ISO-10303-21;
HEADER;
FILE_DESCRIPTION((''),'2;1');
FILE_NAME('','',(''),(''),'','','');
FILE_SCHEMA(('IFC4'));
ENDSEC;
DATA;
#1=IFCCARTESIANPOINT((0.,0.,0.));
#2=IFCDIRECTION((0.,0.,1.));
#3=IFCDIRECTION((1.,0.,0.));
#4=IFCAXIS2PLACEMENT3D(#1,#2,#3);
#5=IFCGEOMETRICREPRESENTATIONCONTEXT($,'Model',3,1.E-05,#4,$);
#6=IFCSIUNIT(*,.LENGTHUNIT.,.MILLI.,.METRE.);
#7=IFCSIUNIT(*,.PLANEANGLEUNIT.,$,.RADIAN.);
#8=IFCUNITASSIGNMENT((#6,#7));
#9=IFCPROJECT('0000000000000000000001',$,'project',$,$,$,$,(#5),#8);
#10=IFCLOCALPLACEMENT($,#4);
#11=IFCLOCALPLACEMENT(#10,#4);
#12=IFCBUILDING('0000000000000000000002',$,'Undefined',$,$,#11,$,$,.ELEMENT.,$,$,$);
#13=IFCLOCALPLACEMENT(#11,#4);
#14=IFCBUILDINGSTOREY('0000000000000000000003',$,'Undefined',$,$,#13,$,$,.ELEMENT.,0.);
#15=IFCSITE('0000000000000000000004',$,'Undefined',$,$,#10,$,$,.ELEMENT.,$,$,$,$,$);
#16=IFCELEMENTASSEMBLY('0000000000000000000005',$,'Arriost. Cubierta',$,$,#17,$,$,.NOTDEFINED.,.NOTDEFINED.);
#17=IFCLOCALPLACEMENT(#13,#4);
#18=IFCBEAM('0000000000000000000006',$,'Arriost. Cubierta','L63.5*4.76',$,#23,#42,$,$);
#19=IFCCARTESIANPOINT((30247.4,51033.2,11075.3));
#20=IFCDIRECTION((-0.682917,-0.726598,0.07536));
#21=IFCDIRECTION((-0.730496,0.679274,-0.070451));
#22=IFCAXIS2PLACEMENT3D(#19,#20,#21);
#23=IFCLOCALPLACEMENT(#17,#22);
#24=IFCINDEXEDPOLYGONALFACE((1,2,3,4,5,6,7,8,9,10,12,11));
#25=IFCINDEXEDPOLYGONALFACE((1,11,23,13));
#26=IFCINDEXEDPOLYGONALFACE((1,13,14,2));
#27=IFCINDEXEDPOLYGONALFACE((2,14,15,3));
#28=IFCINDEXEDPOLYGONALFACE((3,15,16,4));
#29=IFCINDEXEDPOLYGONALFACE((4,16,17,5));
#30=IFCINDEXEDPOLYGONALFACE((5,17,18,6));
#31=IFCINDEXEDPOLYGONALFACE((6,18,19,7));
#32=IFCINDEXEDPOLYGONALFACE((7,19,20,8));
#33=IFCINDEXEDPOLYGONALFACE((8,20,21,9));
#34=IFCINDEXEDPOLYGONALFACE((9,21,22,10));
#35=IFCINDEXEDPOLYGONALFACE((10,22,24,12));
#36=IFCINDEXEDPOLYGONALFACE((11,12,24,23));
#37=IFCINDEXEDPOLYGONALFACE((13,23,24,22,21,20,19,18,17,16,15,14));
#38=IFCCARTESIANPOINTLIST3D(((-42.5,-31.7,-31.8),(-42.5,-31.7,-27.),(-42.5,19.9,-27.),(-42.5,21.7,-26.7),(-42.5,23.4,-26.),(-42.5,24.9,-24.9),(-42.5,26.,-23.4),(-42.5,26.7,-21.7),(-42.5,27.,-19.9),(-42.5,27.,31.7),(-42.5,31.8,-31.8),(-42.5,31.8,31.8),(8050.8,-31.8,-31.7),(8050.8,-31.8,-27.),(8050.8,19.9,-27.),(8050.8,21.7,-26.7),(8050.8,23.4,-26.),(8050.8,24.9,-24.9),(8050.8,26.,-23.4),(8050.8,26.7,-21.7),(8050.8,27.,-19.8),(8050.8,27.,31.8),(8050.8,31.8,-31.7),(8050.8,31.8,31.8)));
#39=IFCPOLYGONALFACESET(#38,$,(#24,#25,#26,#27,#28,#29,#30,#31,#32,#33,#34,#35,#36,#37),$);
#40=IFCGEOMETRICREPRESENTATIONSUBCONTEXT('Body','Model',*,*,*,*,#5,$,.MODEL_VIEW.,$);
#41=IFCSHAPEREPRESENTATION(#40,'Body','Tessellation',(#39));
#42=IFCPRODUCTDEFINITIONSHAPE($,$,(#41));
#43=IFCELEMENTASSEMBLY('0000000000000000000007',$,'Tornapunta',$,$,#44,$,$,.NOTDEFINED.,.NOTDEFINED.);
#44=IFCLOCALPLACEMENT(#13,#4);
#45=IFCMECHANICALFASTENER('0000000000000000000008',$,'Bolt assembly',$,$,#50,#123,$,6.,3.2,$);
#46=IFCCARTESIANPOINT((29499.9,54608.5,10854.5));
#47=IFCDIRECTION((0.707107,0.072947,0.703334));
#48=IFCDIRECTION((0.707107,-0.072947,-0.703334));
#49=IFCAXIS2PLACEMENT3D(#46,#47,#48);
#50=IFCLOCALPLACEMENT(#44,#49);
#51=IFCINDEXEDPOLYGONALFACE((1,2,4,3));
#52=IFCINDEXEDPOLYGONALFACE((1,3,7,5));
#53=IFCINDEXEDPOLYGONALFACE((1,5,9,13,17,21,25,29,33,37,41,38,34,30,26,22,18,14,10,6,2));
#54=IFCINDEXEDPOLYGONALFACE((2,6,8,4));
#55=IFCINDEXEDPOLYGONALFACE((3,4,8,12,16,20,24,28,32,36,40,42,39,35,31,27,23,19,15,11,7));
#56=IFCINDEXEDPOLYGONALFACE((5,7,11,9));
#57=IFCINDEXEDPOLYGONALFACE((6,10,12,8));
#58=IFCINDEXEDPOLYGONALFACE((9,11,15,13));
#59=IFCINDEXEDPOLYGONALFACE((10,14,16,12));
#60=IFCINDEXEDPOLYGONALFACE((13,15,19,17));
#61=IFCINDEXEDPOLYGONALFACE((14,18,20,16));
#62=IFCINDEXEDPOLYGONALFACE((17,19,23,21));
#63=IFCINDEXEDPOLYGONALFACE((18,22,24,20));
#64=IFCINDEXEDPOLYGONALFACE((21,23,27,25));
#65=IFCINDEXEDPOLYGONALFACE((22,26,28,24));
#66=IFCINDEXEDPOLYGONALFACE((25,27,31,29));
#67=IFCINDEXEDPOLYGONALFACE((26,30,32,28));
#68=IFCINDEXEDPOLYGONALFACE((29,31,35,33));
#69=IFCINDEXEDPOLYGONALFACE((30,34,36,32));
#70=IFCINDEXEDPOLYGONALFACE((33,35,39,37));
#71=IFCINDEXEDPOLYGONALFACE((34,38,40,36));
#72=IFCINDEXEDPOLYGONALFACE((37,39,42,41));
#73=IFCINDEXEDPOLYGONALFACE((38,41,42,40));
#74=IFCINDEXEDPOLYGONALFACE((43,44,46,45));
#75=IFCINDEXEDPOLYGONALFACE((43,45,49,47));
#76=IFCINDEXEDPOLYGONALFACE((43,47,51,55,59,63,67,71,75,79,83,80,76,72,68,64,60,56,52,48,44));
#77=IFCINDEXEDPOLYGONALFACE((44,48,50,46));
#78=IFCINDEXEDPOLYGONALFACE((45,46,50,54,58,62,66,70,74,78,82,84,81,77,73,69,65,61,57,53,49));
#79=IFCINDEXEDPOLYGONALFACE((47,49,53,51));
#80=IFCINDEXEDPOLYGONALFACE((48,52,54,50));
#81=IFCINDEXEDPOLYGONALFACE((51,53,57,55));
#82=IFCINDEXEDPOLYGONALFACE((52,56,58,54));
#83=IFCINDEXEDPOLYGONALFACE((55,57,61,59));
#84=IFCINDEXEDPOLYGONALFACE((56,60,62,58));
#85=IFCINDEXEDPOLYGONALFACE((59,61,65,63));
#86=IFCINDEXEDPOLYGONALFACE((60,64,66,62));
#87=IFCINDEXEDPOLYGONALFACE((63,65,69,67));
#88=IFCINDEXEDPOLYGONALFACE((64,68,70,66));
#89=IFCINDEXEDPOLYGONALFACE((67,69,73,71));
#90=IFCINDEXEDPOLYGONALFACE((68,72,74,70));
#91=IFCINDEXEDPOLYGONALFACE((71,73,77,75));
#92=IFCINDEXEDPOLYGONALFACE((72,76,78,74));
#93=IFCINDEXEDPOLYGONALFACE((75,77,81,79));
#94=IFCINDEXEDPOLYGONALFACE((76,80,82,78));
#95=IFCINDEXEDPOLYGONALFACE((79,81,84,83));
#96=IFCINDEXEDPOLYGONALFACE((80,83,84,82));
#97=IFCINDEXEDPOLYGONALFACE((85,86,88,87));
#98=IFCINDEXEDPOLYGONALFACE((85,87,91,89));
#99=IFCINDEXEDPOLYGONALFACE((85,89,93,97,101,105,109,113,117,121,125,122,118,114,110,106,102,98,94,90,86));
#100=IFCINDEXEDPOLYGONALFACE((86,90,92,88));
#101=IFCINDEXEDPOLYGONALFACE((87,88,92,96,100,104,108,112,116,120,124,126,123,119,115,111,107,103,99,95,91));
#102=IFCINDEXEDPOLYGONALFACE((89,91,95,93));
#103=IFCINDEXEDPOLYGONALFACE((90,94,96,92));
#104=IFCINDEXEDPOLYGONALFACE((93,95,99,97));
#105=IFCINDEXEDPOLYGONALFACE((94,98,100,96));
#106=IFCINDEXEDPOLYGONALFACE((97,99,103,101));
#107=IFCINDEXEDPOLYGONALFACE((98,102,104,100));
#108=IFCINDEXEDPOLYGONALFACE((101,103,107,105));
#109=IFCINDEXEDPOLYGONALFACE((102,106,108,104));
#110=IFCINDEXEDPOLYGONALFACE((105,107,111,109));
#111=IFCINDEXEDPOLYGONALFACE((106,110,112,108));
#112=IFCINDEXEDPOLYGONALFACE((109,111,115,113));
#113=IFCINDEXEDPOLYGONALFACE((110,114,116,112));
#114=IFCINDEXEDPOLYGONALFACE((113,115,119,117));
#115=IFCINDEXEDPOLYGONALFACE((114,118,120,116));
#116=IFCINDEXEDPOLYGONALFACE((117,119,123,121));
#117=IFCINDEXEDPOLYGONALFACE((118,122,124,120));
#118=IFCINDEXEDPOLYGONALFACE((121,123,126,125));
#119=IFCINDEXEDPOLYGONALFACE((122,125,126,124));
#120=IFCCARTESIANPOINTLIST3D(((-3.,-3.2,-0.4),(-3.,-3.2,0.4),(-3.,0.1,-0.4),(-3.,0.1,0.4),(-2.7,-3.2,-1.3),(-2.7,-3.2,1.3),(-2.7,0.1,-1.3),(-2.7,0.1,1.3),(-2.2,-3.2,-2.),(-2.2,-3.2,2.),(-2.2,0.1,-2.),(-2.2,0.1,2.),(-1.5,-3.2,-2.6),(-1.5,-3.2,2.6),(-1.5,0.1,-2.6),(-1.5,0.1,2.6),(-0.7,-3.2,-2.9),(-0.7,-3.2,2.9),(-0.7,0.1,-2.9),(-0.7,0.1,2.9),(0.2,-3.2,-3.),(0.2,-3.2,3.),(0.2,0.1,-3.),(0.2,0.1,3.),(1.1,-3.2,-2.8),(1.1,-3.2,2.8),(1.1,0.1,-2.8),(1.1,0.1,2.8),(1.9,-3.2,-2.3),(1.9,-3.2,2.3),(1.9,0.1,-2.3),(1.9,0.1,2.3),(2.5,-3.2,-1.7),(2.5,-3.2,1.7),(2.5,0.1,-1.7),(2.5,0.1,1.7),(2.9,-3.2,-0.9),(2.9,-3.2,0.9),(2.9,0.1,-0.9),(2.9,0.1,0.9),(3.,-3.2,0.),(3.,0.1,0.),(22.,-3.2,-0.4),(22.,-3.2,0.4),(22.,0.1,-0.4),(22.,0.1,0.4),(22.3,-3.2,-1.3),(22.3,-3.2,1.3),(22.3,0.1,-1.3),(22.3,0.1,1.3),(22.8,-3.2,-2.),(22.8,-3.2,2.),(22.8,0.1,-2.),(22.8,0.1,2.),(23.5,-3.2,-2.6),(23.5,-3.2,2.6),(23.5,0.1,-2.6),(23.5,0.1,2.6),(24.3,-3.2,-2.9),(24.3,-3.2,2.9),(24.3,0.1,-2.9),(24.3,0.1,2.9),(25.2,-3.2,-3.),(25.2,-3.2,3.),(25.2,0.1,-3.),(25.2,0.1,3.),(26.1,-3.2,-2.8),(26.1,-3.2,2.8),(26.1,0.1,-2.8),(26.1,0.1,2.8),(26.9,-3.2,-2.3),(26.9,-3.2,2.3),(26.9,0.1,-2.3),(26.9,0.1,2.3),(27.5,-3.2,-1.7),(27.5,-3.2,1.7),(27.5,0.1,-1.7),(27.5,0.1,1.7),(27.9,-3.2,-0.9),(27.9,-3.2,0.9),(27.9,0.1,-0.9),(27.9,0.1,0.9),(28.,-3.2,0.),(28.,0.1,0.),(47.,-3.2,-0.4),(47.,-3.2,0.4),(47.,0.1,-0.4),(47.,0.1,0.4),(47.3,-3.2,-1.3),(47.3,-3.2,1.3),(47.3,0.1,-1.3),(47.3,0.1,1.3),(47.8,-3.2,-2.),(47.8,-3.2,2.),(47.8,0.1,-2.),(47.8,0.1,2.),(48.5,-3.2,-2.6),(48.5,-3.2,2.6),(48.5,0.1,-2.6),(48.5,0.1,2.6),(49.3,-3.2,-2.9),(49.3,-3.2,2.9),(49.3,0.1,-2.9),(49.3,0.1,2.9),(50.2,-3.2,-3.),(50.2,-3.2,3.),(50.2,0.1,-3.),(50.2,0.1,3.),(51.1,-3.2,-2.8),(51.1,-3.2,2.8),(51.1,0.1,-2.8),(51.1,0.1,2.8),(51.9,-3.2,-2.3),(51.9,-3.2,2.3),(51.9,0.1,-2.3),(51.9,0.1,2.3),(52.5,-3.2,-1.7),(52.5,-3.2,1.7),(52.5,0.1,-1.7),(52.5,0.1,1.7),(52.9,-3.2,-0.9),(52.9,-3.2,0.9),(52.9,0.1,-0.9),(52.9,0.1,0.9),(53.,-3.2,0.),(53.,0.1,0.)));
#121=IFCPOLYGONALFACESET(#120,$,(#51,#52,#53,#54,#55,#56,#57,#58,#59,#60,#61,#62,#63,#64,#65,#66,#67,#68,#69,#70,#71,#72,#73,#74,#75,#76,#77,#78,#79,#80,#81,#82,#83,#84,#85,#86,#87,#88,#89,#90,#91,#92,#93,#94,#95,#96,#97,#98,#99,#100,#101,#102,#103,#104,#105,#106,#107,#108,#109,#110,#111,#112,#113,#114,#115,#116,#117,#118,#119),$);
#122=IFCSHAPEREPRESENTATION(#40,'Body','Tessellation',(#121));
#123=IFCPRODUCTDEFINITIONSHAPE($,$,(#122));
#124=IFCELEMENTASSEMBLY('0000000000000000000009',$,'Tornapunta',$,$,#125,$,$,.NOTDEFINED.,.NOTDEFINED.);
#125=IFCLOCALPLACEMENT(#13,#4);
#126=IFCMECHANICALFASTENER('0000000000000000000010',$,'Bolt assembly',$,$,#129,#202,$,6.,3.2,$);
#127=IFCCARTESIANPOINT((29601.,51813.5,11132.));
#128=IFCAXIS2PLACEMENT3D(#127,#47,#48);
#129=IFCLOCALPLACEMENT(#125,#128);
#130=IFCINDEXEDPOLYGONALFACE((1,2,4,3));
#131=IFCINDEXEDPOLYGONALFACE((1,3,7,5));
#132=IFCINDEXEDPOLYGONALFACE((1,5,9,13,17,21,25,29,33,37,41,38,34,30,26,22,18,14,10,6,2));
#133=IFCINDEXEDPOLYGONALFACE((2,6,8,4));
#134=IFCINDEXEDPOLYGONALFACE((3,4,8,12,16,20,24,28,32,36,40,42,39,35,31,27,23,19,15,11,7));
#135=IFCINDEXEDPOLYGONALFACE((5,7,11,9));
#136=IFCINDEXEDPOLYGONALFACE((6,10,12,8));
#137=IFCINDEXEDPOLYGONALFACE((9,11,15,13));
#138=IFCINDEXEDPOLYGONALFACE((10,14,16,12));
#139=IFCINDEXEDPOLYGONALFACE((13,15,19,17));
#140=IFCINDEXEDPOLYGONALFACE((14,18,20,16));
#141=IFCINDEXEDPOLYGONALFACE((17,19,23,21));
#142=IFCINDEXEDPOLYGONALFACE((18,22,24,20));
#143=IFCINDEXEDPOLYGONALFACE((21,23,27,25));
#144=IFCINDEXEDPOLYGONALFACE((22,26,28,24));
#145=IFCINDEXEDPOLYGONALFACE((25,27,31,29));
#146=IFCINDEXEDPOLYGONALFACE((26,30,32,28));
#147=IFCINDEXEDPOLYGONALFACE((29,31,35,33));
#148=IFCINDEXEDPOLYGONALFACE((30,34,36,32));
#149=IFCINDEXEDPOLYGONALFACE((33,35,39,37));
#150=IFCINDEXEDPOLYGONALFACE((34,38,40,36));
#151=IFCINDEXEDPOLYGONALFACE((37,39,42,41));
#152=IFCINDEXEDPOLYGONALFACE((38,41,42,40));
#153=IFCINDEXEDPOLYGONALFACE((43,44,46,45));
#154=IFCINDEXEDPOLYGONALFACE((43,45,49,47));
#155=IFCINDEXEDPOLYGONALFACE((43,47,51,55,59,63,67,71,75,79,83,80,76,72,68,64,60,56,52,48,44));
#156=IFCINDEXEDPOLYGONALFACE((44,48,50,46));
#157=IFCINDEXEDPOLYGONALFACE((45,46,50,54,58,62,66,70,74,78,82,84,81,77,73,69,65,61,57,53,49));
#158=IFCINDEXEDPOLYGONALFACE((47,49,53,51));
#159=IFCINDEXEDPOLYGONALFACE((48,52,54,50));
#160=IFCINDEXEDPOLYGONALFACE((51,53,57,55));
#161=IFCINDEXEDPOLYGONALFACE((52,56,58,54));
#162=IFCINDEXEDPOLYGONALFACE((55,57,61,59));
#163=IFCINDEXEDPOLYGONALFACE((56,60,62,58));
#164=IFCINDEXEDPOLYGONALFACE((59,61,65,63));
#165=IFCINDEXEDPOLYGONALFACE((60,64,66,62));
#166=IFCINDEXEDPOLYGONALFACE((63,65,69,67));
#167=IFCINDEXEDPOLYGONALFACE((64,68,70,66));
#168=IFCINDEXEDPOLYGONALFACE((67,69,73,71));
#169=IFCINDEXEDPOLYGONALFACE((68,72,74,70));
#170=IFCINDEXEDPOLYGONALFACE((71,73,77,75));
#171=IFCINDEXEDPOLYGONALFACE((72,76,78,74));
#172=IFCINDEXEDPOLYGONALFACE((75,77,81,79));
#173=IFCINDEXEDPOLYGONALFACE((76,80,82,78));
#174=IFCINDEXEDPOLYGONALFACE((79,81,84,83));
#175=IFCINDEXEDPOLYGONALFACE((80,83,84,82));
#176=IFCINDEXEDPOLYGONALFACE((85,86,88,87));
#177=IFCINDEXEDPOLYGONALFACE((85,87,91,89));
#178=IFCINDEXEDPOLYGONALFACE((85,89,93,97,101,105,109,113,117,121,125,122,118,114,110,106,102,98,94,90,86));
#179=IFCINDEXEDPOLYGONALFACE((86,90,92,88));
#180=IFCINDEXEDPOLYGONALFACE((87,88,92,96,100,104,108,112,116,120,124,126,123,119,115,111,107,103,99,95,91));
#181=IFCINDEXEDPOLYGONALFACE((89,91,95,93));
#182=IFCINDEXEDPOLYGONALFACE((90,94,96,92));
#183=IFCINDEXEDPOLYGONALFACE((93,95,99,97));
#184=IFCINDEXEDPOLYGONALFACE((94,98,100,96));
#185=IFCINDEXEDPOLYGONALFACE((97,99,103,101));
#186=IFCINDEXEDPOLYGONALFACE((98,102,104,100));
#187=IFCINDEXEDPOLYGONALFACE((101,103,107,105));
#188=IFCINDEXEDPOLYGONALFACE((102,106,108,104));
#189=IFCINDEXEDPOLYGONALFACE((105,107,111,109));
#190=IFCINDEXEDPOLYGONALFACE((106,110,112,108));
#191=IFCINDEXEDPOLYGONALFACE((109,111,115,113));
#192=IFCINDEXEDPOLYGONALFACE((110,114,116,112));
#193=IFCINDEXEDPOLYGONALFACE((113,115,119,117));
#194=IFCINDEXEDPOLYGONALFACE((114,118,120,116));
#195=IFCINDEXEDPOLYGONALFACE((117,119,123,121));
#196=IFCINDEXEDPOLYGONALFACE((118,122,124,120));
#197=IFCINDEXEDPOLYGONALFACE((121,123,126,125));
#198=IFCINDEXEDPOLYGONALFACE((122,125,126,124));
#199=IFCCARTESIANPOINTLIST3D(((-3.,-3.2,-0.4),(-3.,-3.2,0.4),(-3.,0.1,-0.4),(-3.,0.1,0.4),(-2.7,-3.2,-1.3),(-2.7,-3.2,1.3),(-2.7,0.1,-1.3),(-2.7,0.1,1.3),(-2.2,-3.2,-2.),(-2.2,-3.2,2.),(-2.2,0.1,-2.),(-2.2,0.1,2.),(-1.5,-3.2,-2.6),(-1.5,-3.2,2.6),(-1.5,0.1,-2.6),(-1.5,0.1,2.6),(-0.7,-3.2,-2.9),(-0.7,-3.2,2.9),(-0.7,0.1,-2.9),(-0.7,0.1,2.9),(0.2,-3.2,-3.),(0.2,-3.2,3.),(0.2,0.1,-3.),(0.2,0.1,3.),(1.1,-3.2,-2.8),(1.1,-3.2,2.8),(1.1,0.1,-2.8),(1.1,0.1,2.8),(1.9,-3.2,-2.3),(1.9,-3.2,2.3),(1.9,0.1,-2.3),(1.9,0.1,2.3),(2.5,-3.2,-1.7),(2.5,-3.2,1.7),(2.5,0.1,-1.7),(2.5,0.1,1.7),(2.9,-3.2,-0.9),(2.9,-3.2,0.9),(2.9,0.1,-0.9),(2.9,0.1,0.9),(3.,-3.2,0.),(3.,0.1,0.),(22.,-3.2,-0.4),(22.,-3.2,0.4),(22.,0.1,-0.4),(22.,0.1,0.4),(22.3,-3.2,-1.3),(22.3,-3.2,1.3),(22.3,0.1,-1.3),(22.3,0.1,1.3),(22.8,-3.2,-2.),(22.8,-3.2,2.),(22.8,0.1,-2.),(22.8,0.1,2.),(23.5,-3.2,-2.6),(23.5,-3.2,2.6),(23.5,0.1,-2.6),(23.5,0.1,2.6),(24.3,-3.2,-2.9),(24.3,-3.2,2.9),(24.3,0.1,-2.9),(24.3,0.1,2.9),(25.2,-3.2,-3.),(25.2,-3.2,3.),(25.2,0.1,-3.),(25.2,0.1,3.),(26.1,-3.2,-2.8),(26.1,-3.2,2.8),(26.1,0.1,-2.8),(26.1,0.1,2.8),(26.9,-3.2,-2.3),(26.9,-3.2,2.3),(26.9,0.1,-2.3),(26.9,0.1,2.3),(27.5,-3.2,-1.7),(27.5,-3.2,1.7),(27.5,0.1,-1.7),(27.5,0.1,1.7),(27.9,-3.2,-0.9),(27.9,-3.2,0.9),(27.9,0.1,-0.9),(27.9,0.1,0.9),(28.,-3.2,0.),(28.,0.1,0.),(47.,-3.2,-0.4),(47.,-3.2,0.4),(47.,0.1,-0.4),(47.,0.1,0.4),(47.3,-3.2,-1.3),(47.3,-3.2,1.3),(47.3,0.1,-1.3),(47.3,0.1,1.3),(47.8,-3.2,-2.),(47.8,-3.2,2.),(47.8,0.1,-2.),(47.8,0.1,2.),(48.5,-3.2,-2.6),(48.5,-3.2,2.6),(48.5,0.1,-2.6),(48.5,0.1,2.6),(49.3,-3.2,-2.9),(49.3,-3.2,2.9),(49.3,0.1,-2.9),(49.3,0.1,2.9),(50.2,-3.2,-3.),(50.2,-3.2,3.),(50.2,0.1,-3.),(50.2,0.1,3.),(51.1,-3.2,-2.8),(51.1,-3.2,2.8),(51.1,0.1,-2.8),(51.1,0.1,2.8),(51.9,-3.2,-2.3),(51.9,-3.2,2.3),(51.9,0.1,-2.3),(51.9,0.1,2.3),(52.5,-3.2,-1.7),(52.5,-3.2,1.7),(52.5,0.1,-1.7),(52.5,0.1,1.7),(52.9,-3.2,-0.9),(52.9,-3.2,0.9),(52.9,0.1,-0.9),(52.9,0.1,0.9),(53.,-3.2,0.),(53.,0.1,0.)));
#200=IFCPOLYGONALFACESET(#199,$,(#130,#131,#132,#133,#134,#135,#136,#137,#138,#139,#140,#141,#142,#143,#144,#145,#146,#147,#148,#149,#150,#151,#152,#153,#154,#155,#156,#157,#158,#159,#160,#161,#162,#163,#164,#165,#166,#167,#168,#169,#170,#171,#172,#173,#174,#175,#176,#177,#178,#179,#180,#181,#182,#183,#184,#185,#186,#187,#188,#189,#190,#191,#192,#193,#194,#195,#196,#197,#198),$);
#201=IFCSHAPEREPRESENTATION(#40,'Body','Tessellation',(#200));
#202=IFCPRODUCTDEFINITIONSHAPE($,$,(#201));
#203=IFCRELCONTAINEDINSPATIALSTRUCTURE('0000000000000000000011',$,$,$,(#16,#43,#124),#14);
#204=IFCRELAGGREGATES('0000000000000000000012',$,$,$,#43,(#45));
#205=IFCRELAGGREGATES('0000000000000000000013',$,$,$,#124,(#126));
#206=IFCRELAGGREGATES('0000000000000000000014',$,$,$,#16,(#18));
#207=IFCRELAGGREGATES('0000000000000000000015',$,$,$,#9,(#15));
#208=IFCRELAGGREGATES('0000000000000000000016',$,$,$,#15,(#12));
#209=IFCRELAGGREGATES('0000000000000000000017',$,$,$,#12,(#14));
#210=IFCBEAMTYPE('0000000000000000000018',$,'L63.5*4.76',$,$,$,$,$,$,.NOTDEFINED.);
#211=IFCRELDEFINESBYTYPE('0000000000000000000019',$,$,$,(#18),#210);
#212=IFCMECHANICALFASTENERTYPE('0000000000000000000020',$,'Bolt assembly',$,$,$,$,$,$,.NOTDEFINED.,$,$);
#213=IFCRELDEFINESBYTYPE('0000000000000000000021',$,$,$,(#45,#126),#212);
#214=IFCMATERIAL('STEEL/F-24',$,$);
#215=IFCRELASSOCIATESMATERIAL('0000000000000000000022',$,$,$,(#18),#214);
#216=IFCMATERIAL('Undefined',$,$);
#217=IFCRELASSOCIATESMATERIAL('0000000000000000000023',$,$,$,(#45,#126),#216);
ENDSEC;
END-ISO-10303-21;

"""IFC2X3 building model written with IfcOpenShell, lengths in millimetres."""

from ifc_helpers import new_model, si_unit, frame, origin_with_axes, origin_2d_with_axis, place, context, subcontext, project, spatial, circle, l_section, extrude, clip, halfspace, source, transform, mapped, material, type_object, element, aggregate, save


model = new_model("IFC2X3")

# Units and contexts
model_context = context("Model", 3, precision=1e-05, world=origin_with_axes())
body_context = subcontext(model_context, "Body", "Model", "MODEL_VIEW")
ifc_project = project(units=[si_unit("LENGTHUNIT", "METRE", prefix="MILLI"), si_unit("PLANEANGLEUNIT", "RADIAN")], contexts=[model_context])

# Site, building, storey
site_placement = place(None, origin_with_axes())
site = spatial("IfcSite", under=ifc_project, at=site_placement, Name="Undefined", CompositionType="ELEMENT")
building_placement = place(site_placement, origin_with_axes())
building = spatial("IfcBuilding", under=site, at=building_placement, Name="Undefined", CompositionType="ELEMENT")
storey_placement = place(building_placement, origin_with_axes())
storey = spatial("IfcBuildingStorey", under=building, at=storey_placement, Name="Undefined", CompositionType="ELEMENT", Elevation=0.0)

# Shared definitions
ifc_material_1 = material(Name="STEEL/F-24")

# Element assembly, beam
beam_type_1 = type_object("IfcBeamType", Name="L63.5*4.76", PredefinedType="NOTDEFINED")
assembly_1_placement = place(storey_placement, origin_with_axes())
assembly_1 = element("IfcElementAssembly", 1, at=assembly_1_placement, inside=storey, Name="Arriost. Cubierta", AssemblyPlace="NOTDEFINED", PredefinedType="NOTDEFINED")
beam_1_placement = place(assembly_1_placement, frame((30247.4, 51033.2, 11075.3), z_axis=(-0.682917, -0.726598, 0.07536), x_axis=(-0.730496, 0.679274, -0.070451)))
beam_1 = element("IfcBeam", 2, at=beam_1_placement, type_object=beam_type_1, material=ifc_material_1, Name="Arriost. Cubierta", Description="L63.5*4.76", context=body_context, shape_type="Clipping", body=[
    clip(clip(extrude(l_section(Depth=63.5, Width=63.5, Thickness=4.8, FilletRadius=7.1, at=origin_2d_with_axis()), frame((8123.5, 0.0, 0.0), z_axis=(-1.0, 0.0, 0.0), x_axis=(0.0, -1.0, 0.0)), (0.0, 0.0, 1.0), 8238.6), halfspace(frame((8050.8, 31.8, 0.0), z_axis=(-1.0, 0.0, 0.0), x_axis=(0.0, 0.0, 1.0)), True)), halfspace(frame((-42.5, 31.8, 0.0), z_axis=(1.0, 0.0, 0.0), x_axis=(0.0, 0.0, -1.0)), True)),
])

# Element assembly, mechanical fastener
assembly_2_placement = place(storey_placement, origin_with_axes())
assembly_2 = element("IfcElementAssembly", 3, at=assembly_2_placement, inside=storey, Name="Tornapunta", AssemblyPlace="NOTDEFINED", PredefinedType="NOTDEFINED")
ifc_material_2 = material(Name="Undefined")
mechanical_fastener_type = type_object("IfcMechanicalFastenerType", Name="Bolt assembly")
shared_shape_1 = source(origin_with_axes(), body_context, "Body", "SweptSolid", [
    extrude(circle(Radius=3.0, at=origin_2d_with_axis()), frame((0.0, -3.2, 0.0), z_axis=(0.0, 1.0, 0.0), x_axis=(1.0, 0.0, 0.0)), (0.0, 0.0, 1.0), 3.3),
])
mechanical_fastener_1_placement = place(assembly_2_placement, frame((29499.9, 54608.5, 10854.5), z_axis=(0.707107, 0.072947, 0.703334), x_axis=(0.707107, -0.072947, -0.703334)))
mechanical_fastener_1 = element("IfcMechanicalFastener", 4, at=mechanical_fastener_1_placement, type_object=mechanical_fastener_type, material=ifc_material_2, Name="Bolt assembly", NominalDiameter=6.0, NominalLength=3.2, context=body_context, shape_type="MappedRepresentation", body=[
    mapped(shared_shape_1, transform((0.0, 0.0, 0.0))),
    mapped(shared_shape_1, transform((25.0, 0.0, 0.0))),
    mapped(shared_shape_1, transform((50.0, 0.0, 0.0))),
])
aggregate(assembly_2, [mechanical_fastener_1])

# Element assembly, mechanical fastener
assembly_3_placement = place(storey_placement, origin_with_axes())
assembly_3 = element("IfcElementAssembly", 5, at=assembly_3_placement, inside=storey, Name="Tornapunta", AssemblyPlace="NOTDEFINED", PredefinedType="NOTDEFINED")
shared_shape_2 = source(origin_with_axes(), body_context, "Body", "SweptSolid", [
    extrude(circle(Radius=3.0, at=origin_2d_with_axis()), frame((0.0, -3.2, 0.0), z_axis=(0.0, 1.0, 0.0), x_axis=(1.0, 0.0, 0.0)), (0.0, 0.0, 1.0), 3.3),
])
mechanical_fastener_2_placement = place(assembly_3_placement, frame((29601.0, 51813.5, 11132.0), z_axis=(0.707107, 0.072947, 0.703334), x_axis=(0.707107, -0.072947, -0.703334)))
mechanical_fastener_2 = element("IfcMechanicalFastener", 6, at=mechanical_fastener_2_placement, type_object=mechanical_fastener_type, material=ifc_material_2, Name="Bolt assembly", NominalDiameter=6.0, NominalLength=3.2, context=body_context, shape_type="MappedRepresentation", body=[
    mapped(shared_shape_2, transform((0.0, 0.0, 0.0))),
    mapped(shared_shape_2, transform((25.0, 0.0, 0.0))),
    mapped(shared_shape_2, transform((50.0, 0.0, 0.0))),
])
aggregate(assembly_3, [mechanical_fastener_2])

aggregate(assembly_1, [beam_1])

save(model, "model.ifc")
